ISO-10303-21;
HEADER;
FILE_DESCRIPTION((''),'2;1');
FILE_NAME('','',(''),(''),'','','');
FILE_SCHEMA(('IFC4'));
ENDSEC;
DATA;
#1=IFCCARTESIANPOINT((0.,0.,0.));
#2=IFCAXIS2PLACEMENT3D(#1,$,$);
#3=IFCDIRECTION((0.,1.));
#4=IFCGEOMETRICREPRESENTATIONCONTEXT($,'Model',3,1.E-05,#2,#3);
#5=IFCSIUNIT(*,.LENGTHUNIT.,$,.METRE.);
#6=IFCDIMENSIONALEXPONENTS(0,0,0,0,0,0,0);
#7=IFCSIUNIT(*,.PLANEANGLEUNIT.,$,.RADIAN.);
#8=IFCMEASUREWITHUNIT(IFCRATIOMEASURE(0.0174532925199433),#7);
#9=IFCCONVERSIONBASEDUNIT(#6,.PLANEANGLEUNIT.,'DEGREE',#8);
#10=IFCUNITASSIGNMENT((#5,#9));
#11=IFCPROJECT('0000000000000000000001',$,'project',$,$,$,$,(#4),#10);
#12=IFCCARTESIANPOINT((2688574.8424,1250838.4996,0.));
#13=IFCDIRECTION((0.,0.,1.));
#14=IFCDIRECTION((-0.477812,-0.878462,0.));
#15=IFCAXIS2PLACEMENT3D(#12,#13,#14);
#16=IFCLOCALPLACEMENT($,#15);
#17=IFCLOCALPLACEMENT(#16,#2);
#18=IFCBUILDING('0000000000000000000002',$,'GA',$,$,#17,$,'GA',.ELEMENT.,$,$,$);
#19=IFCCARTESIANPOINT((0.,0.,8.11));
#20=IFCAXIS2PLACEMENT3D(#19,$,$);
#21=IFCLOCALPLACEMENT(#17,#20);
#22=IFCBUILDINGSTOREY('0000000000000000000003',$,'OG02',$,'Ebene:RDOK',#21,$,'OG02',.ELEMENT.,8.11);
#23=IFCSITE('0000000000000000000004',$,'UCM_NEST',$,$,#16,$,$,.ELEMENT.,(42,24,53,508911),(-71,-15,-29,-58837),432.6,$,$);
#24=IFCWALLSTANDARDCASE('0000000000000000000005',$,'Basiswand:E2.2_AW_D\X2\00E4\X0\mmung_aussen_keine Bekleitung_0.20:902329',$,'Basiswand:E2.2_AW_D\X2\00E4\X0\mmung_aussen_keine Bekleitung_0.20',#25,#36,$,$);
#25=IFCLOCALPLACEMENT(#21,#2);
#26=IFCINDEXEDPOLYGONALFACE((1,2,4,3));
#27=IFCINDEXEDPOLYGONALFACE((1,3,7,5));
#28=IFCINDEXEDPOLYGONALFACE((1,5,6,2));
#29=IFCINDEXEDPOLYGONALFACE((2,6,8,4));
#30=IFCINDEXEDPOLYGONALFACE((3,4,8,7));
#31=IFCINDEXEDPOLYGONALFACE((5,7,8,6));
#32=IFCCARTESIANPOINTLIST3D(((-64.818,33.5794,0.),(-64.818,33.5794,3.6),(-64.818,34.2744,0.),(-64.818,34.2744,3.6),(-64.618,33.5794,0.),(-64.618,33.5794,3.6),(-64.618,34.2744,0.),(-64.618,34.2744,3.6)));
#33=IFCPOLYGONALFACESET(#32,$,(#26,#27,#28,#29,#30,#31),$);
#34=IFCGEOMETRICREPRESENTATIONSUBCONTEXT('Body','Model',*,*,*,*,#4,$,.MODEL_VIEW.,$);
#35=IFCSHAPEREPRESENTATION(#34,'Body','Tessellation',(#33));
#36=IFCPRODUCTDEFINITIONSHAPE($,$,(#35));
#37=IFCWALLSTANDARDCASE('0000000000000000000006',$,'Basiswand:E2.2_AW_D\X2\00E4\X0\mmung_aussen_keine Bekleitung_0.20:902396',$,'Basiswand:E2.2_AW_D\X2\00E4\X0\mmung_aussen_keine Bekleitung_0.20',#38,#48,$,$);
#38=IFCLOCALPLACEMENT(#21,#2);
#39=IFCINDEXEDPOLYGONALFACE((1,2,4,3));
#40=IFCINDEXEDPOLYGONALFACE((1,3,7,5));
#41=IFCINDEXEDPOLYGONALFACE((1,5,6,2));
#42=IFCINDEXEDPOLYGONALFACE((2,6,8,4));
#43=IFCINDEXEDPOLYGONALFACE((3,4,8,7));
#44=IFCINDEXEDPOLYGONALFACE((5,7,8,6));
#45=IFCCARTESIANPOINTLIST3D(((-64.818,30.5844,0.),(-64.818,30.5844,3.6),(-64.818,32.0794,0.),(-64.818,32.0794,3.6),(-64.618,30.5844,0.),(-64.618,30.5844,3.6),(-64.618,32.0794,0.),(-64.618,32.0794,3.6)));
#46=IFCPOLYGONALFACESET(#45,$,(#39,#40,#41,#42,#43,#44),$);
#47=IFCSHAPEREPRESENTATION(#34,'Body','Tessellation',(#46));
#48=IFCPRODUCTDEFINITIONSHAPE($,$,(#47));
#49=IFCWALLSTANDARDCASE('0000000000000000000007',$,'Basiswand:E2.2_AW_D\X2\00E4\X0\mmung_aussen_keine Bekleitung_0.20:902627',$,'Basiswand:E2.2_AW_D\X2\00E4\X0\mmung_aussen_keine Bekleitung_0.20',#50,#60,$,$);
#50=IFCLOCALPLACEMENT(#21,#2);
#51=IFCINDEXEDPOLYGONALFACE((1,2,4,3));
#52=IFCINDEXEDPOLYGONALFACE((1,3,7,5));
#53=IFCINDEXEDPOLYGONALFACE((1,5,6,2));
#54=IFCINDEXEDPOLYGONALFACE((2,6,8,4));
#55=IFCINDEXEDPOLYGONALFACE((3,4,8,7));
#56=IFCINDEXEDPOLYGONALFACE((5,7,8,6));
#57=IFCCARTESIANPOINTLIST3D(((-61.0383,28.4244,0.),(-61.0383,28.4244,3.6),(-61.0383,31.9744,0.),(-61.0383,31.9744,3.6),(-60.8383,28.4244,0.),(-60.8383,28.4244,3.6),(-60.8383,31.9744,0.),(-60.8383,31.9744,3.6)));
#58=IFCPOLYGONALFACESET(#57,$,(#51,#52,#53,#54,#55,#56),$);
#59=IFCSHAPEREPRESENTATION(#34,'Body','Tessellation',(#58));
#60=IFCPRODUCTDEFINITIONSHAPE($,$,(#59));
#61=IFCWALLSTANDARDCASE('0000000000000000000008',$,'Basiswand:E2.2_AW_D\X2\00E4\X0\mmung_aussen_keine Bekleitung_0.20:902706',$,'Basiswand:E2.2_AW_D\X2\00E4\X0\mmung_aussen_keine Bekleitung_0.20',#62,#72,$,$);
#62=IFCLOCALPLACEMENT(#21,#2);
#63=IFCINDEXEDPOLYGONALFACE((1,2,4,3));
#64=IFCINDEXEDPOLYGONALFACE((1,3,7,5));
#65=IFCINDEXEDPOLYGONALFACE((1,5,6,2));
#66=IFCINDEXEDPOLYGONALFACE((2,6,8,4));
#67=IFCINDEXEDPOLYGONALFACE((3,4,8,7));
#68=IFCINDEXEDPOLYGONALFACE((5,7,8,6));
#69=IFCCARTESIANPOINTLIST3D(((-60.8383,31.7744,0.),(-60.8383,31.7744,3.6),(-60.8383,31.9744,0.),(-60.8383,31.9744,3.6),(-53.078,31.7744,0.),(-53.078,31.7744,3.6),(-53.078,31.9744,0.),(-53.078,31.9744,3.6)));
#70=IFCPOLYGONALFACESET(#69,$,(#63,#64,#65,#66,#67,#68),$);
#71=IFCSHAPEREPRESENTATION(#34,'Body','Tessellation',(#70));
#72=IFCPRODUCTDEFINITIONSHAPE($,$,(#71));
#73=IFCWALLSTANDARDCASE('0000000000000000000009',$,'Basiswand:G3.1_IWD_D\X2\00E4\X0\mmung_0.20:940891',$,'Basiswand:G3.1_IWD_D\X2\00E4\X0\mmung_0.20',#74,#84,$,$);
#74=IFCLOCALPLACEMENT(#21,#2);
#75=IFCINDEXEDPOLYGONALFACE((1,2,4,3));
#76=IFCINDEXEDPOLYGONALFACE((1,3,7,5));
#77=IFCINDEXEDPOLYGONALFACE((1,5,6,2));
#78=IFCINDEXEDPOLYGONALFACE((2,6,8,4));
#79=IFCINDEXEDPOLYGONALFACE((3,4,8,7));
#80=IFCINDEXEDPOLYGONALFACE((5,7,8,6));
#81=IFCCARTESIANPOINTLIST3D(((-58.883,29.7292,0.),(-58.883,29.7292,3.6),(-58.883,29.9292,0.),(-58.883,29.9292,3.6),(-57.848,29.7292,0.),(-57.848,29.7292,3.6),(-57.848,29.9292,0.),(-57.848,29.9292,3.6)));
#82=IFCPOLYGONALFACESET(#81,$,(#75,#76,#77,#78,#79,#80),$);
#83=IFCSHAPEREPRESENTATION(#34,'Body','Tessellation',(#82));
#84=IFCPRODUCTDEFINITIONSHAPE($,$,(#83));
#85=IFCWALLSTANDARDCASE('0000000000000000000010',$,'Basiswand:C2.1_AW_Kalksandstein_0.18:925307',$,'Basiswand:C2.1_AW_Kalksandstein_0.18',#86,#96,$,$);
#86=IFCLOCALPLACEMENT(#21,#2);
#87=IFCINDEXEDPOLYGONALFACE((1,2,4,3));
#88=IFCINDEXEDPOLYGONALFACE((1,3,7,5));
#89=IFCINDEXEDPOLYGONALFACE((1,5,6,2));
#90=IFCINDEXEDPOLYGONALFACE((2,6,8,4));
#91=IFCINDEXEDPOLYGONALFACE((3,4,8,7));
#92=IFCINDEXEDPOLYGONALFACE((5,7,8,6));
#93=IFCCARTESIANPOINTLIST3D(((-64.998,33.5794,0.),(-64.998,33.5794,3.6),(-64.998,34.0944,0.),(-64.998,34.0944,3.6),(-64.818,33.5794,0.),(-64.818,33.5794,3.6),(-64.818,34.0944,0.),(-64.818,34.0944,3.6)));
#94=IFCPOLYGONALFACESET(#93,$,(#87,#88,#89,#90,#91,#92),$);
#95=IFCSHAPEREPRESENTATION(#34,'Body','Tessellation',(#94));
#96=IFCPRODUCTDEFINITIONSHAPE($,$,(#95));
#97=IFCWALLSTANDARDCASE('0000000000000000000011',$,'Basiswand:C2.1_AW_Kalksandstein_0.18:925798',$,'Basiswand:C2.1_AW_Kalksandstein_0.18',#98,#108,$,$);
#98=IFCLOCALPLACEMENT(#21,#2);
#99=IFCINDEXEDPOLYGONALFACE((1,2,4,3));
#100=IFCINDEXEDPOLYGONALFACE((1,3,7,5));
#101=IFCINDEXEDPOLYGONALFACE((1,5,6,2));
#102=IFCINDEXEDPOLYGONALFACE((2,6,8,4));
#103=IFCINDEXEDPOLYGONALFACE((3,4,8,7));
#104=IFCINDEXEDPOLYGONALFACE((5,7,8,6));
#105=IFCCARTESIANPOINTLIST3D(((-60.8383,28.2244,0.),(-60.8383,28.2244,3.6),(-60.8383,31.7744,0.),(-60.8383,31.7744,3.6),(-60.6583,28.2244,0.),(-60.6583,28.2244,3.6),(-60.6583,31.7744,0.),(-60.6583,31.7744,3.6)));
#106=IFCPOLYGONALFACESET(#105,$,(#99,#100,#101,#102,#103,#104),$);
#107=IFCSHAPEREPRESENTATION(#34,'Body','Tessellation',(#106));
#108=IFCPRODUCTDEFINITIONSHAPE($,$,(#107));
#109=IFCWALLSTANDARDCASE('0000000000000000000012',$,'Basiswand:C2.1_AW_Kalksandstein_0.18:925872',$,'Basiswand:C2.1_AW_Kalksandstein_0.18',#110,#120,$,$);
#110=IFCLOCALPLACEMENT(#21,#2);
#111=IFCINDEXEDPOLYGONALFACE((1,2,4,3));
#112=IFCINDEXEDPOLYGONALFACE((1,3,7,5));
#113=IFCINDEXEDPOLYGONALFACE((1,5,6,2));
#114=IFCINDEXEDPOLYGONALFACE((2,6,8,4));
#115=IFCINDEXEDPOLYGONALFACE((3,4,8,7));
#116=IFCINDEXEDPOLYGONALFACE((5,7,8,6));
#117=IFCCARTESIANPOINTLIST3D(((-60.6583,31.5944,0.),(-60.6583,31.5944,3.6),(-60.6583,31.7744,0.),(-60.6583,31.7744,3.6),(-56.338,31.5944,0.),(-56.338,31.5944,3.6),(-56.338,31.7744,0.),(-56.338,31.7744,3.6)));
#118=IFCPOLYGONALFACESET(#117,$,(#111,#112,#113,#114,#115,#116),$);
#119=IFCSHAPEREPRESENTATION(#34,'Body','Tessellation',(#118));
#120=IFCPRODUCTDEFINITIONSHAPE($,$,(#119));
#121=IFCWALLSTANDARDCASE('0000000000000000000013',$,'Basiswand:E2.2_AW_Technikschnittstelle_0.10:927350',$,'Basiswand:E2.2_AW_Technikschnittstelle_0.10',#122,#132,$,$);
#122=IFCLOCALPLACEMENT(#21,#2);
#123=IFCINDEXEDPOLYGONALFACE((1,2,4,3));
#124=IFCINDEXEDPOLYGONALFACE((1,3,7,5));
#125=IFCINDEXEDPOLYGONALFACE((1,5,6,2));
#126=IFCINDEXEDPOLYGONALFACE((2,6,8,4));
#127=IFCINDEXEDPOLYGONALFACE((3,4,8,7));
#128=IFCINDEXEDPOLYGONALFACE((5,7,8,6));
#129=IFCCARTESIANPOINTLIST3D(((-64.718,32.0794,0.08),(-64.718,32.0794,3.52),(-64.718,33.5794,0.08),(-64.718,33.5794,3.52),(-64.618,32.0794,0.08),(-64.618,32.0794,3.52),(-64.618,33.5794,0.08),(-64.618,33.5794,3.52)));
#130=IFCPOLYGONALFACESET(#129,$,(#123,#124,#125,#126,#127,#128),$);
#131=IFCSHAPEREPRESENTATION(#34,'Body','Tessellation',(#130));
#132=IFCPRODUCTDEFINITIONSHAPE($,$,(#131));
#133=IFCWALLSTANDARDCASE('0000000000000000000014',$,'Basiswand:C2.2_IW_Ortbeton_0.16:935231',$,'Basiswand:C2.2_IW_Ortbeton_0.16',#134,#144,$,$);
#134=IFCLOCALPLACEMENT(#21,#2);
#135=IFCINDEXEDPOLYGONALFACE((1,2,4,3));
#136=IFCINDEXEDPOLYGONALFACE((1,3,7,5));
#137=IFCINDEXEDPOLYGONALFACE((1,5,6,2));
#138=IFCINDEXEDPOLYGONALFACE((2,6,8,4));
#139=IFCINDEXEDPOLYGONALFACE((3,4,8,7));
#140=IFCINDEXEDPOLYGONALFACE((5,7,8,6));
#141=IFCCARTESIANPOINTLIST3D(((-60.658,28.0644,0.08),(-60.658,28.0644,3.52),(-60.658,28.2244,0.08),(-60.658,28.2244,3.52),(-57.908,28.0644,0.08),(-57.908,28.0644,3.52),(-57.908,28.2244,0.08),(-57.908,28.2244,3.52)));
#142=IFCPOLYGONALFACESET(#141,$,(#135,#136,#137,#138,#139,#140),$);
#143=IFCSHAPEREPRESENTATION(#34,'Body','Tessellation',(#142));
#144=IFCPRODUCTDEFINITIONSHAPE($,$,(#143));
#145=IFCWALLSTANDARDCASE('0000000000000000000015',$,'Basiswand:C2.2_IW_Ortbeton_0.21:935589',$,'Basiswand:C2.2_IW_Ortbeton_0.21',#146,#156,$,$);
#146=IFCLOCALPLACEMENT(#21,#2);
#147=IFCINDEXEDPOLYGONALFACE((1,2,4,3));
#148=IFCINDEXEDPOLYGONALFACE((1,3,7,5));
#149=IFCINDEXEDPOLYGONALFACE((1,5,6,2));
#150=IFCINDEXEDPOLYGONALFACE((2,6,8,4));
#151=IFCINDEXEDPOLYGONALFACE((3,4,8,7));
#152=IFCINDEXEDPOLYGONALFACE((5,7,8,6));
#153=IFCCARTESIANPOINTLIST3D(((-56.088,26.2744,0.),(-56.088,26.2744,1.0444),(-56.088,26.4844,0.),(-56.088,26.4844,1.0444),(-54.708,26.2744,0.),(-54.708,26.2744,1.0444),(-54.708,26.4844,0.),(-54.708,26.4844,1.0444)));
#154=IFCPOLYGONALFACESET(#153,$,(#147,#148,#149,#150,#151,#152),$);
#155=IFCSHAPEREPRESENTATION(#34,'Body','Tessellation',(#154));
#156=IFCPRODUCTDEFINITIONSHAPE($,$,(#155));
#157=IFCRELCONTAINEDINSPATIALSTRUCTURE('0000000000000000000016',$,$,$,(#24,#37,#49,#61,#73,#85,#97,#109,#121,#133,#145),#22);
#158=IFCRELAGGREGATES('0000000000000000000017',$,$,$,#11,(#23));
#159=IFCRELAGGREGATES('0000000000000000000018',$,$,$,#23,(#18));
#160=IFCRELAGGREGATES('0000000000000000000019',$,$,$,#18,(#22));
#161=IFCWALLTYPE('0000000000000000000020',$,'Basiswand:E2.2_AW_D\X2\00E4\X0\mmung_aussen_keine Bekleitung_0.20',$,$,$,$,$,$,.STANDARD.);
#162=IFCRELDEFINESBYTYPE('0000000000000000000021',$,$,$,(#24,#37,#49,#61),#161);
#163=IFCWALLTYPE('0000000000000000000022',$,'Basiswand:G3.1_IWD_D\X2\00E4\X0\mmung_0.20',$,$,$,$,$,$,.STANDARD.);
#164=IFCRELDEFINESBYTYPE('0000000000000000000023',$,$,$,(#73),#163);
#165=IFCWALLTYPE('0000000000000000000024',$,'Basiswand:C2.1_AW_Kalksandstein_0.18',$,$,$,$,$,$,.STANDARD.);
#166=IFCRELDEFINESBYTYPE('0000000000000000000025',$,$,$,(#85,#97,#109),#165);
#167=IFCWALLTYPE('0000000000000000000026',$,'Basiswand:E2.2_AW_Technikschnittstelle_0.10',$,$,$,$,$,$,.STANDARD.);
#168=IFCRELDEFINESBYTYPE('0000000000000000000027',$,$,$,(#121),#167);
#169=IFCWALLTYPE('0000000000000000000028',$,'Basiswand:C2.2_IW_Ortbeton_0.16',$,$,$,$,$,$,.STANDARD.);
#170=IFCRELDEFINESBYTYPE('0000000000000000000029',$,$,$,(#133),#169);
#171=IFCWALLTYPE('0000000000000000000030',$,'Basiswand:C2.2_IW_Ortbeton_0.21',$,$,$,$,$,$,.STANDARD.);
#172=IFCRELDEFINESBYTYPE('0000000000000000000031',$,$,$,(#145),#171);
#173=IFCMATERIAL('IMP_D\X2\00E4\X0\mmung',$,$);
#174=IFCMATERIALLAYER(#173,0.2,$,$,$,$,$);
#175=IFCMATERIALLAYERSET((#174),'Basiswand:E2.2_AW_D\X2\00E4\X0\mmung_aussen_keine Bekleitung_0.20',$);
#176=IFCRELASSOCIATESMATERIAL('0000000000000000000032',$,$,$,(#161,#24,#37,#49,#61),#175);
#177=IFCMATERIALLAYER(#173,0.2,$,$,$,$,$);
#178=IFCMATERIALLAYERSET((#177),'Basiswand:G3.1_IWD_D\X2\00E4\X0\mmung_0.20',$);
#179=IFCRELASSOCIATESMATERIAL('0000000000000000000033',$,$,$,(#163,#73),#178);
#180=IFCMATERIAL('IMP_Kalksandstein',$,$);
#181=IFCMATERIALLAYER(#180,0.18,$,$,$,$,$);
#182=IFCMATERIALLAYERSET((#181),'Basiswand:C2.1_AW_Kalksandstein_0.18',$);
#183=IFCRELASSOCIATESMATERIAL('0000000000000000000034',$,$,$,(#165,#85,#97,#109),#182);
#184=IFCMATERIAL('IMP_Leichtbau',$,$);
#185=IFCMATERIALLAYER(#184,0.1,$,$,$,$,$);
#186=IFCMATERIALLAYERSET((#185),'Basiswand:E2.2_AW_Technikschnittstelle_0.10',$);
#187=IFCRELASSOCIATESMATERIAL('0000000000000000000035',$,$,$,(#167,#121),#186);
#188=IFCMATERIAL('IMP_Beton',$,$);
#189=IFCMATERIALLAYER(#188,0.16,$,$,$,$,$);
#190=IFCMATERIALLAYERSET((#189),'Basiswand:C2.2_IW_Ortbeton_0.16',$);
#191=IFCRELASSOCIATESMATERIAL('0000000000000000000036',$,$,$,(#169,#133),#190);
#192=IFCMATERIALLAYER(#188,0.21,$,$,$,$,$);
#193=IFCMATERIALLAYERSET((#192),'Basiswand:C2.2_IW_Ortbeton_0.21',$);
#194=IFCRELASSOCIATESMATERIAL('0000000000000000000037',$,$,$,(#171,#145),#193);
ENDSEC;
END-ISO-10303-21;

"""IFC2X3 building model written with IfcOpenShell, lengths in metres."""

from ifc_helpers import new_model, entity, si_unit, converted_unit, direction, frame, frame_2d, origin, place, context, subcontext, project, spatial, polyline, rectangle, extrude, clip, bounded_halfspace, material, layer, layer_set, layer_usage, type_object, element, save


model = new_model("IFC2X3")

# Units and contexts
model_context = context("Model", 3, precision=1e-05, world=origin(), true_north=direction((0.0, 1.0)))
body_context = subcontext(model_context, "Body", "Model", "MODEL_VIEW")
ifc_project = project(units=[si_unit("LENGTHUNIT", "METRE"), converted_unit("PLANEANGLEUNIT", "DEGREE", entity("IfcRatioMeasure", 0.0174532925199433), si_unit("PLANEANGLEUNIT", "RADIAN"), dimensions=[0, 0, 0, 0, 0, 0, 0])], contexts=[model_context])

# Site, building, storey
site_placement = place(None, frame((2688574.8424, 1250838.4996, 0.0), z_axis=(0.0, 0.0, 1.0), x_axis=(-0.477812, -0.878462, 0.0)))
site = spatial("IfcSite", under=ifc_project, at=site_placement, Name="UCM_NEST", CompositionType="ELEMENT", RefLatitude=(42, 24, 53, 508911), RefLongitude=(-71, -15, -29, -58837), RefElevation=432.6)
building_placement = place(site_placement, origin())
building = spatial("IfcBuilding", under=site, at=building_placement, Name="GA", LongName="GA", CompositionType="ELEMENT")
storey_placement = place(building_placement, frame((0.0, 0.0, 8.11)))
storey = spatial("IfcBuildingStorey", under=building, at=storey_placement, Name="OG02", ObjectType="Ebene:RDOK", LongName="OG02", CompositionType="ELEMENT", Elevation=8.11)

# Walls
ifc_material_1 = material(Name="IMP_Dämmung")
ifc_layer_1 = layer(ifc_material_1, 0.2)
ifc_layer_set_1 = layer_set([ifc_layer_1], Name="Basiswand:E2.2_AW_Dämmung_aussen_keine Bekleitung_0.20")
ifc_layer_usage_1 = layer_usage(ifc_layer_set_1, "AXIS2", "NEGATIVE", 0.1)
wall_type_1 = type_object("IfcWallType", Name="Basiswand:E2.2_AW_Dämmung_aussen_keine Bekleitung_0.20", PredefinedType="STANDARD", material=ifc_layer_set_1)
wall_1_placement = place(storey_placement, frame((-64.718, 34.2744, 0.0), z_axis=(0.0, 0.0, 1.0), x_axis=(0.0, -1.0, 0.0)))
element("IfcWallStandardCase", 1, at=wall_1_placement, inside=storey, type_object=wall_type_1, material=ifc_layer_usage_1, Name="Basiswand:E2.2_AW_Dämmung_aussen_keine Bekleitung_0.20:902329", ObjectType="Basiswand:E2.2_AW_Dämmung_aussen_keine Bekleitung_0.20", context=body_context, shape_type="SweptSolid", body=[
    extrude(rectangle(XDim=0.695, YDim=0.2, at=frame_2d((0.3475, 0.0), x_axis=(-1.0, 0.0))), origin(), (0.0, 0.0, 1.0), 3.6),
])
ifc_layer_usage_2 = layer_usage(ifc_layer_set_1, "AXIS2", "NEGATIVE", 0.1)
wall_2_placement = place(storey_placement, frame((-64.718, 32.0794, 0.0), z_axis=(0.0, 0.0, 1.0), x_axis=(0.0, -1.0, 0.0)))
element("IfcWallStandardCase", 2, at=wall_2_placement, inside=storey, type_object=wall_type_1, material=ifc_layer_usage_2, Name="Basiswand:E2.2_AW_Dämmung_aussen_keine Bekleitung_0.20:902396", ObjectType="Basiswand:E2.2_AW_Dämmung_aussen_keine Bekleitung_0.20", context=body_context, shape_type="SweptSolid", body=[
    extrude(rectangle(XDim=1.495, YDim=0.2, at=frame_2d((0.7475, 0.0), x_axis=(-1.0, 0.0))), origin(), (0.0, 0.0, 1.0), 3.6),
])
ifc_layer_usage_3 = layer_usage(ifc_layer_set_1, "AXIS2", "NEGATIVE", 0.1)
wall_3_placement = place(storey_placement, frame((-60.9383, 28.4244, 0.0), z_axis=(0.0, 0.0, 1.0), x_axis=(0.0, 1.0, 0.0)))
element("IfcWallStandardCase", 3, at=wall_3_placement, inside=storey, type_object=wall_type_1, material=ifc_layer_usage_3, Name="Basiswand:E2.2_AW_Dämmung_aussen_keine Bekleitung_0.20:902627", ObjectType="Basiswand:E2.2_AW_Dämmung_aussen_keine Bekleitung_0.20", context=body_context, shape_type="SweptSolid", body=[
    extrude(rectangle(XDim=3.55, YDim=0.2, at=frame_2d((1.775, 0.0), x_axis=(-1.0, 0.0))), origin(), (0.0, 0.0, 1.0), 3.6),
])
ifc_layer_usage_4 = layer_usage(ifc_layer_set_1, "AXIS2", "NEGATIVE", 0.1)
wall_4_placement = place(storey_placement, frame((-60.8383, 31.8744, 0.0)))
element("IfcWallStandardCase", 4, at=wall_4_placement, inside=storey, type_object=wall_type_1, material=ifc_layer_usage_4, Name="Basiswand:E2.2_AW_Dämmung_aussen_keine Bekleitung_0.20:902706", ObjectType="Basiswand:E2.2_AW_Dämmung_aussen_keine Bekleitung_0.20", context=body_context, shape_type="SweptSolid", body=[
    extrude(rectangle(XDim=7.7603, YDim=0.2, at=frame_2d((3.8801, 0.0), x_axis=(-1.0, 0.0))), origin(), (0.0, 0.0, 1.0), 3.6),
])
ifc_layer_2 = layer(ifc_material_1, 0.2)
ifc_layer_set_2 = layer_set([ifc_layer_2], Name="Basiswand:G3.1_IWD_Dämmung_0.20")
ifc_layer_usage_5 = layer_usage(ifc_layer_set_2, "AXIS2", "NEGATIVE", 0.1)
wall_type_2 = type_object("IfcWallType", Name="Basiswand:G3.1_IWD_Dämmung_0.20", PredefinedType="STANDARD", material=ifc_layer_set_2)
wall_5_placement = place(storey_placement, frame((-57.848, 29.8292, 0.0), z_axis=(0.0, 0.0, 1.0), x_axis=(-1.0, 0.0, 0.0)))
element("IfcWallStandardCase", 5, at=wall_5_placement, inside=storey, type_object=wall_type_2, material=ifc_layer_usage_5, Name="Basiswand:G3.1_IWD_Dämmung_0.20:940891", ObjectType="Basiswand:G3.1_IWD_Dämmung_0.20", context=body_context, shape_type="SweptSolid", body=[
    extrude(rectangle(XDim=1.035, YDim=0.2, at=frame_2d((0.5175, 0.0), x_axis=(-1.0, 0.0))), origin(), (0.0, 0.0, 1.0), 3.6),
])
ifc_material_2 = material(Name="IMP_Kalksandstein")
ifc_layer_3 = layer(ifc_material_2, 0.18)
ifc_layer_set_3 = layer_set([ifc_layer_3], Name="Basiswand:C2.1_AW_Kalksandstein_0.18")
ifc_layer_usage_6 = layer_usage(ifc_layer_set_3, "AXIS2", "NEGATIVE", 0.09)
wall_type_3 = type_object("IfcWallType", Name="Basiswand:C2.1_AW_Kalksandstein_0.18", PredefinedType="STANDARD", material=ifc_layer_set_3)
wall_6_placement = place(storey_placement, frame((-64.908, 34.0944, 0.0), z_axis=(0.0, 0.0, 1.0), x_axis=(0.0, -1.0, 0.0)))
element("IfcWallStandardCase", 6, at=wall_6_placement, inside=storey, type_object=wall_type_3, material=ifc_layer_usage_6, Name="Basiswand:C2.1_AW_Kalksandstein_0.18:925307", ObjectType="Basiswand:C2.1_AW_Kalksandstein_0.18", context=body_context, shape_type="SweptSolid", body=[
    extrude(rectangle(XDim=0.515, YDim=0.18, at=frame_2d((0.2575, 0.0), x_axis=(-1.0, 0.0))), origin(), (0.0, 0.0, 1.0), 3.6),
])
ifc_layer_usage_7 = layer_usage(ifc_layer_set_3, "AXIS2", "NEGATIVE", 0.09)
wall_7_placement = place(storey_placement, frame((-60.7483, 28.2244, 0.0), z_axis=(0.0, 0.0, 1.0), x_axis=(0.0, 1.0, 0.0)))
element("IfcWallStandardCase", 7, at=wall_7_placement, inside=storey, type_object=wall_type_3, material=ifc_layer_usage_7, Name="Basiswand:C2.1_AW_Kalksandstein_0.18:925798", ObjectType="Basiswand:C2.1_AW_Kalksandstein_0.18", context=body_context, shape_type="SweptSolid", body=[
    extrude(rectangle(XDim=3.55, YDim=0.18, at=frame_2d((1.775, 0.0), x_axis=(-1.0, 0.0))), origin(), (0.0, 0.0, 1.0), 3.6),
])
ifc_layer_usage_8 = layer_usage(ifc_layer_set_3, "AXIS2", "NEGATIVE", 0.09)
wall_8_placement = place(storey_placement, frame((-60.6583, 31.6844, 0.0)))
element("IfcWallStandardCase", 8, at=wall_8_placement, inside=storey, type_object=wall_type_3, material=ifc_layer_usage_8, Name="Basiswand:C2.1_AW_Kalksandstein_0.18:925872", ObjectType="Basiswand:C2.1_AW_Kalksandstein_0.18", context=body_context, shape_type="SweptSolid", body=[
    extrude(rectangle(XDim=4.3203, YDim=0.18, at=frame_2d((2.1601, 0.0), x_axis=(-1.0, 0.0))), origin(), (0.0, 0.0, 1.0), 3.6),
])
ifc_material_3 = material(Name="IMP_Leichtbau")
ifc_layer_4 = layer(ifc_material_3, 0.1)
ifc_layer_set_4 = layer_set([ifc_layer_4], Name="Basiswand:E2.2_AW_Technikschnittstelle_0.10")
ifc_layer_usage_9 = layer_usage(ifc_layer_set_4, "AXIS2", "NEGATIVE", 0.05)
wall_type_4 = type_object("IfcWallType", Name="Basiswand:E2.2_AW_Technikschnittstelle_0.10", PredefinedType="STANDARD", material=ifc_layer_set_4)
wall_9_placement = place(storey_placement, frame((-64.668, 33.5794, 0.08), z_axis=(0.0, 0.0, 1.0), x_axis=(0.0, -1.0, 0.0)))
element("IfcWallStandardCase", 9, at=wall_9_placement, inside=storey, type_object=wall_type_4, material=ifc_layer_usage_9, Name="Basiswand:E2.2_AW_Technikschnittstelle_0.10:927350", ObjectType="Basiswand:E2.2_AW_Technikschnittstelle_0.10", context=body_context, shape_type="Clipping", body=[
    clip(clip(extrude(rectangle(XDim=1.5, YDim=0.1, at=frame_2d((0.75, 0.0), x_axis=(-1.0, 0.0))), origin(), (0.0, 0.0, 1.0), 3.44), bounded_halfspace(frame((1.5, -0.05, 0.0), z_axis=(0.0, 0.0, 1.0), x_axis=(0.0, -1.0, 0.0)), True, frame((1.5, -0.05, 0.0), z_axis=(0.0, 0.0, 1.0), x_axis=(0.0, -1.0, 0.0)), polyline([(0.0, 0.0), (-0.1, 0.0), (-0.1, -1.5), (0.0, -1.5), (0.0, 0.0)]))), bounded_halfspace(frame((0.0, -0.05, 3.44), z_axis=(0.0, 0.0, -1.0), x_axis=(0.0, -1.0, 0.0)), True, frame((0.0, -0.05, 3.44), z_axis=(0.0, 0.0, -1.0), x_axis=(0.0, -1.0, 0.0)), polyline([(0.0, 0.0), (-0.1, 0.0), (-0.1, -1.5), (0.0, -1.5), (0.0, 0.0)]))),
])
ifc_material_4 = material(Name="IMP_Beton")
ifc_layer_5 = layer(ifc_material_4, 0.16)
ifc_layer_set_5 = layer_set([ifc_layer_5], Name="Basiswand:C2.2_IW_Ortbeton_0.16")
ifc_layer_usage_10 = layer_usage(ifc_layer_set_5, "AXIS2", "NEGATIVE", 0.08)
wall_type_5 = type_object("IfcWallType", Name="Basiswand:C2.2_IW_Ortbeton_0.16", PredefinedType="STANDARD", material=ifc_layer_set_5)
wall_10_placement = place(storey_placement, frame((-60.658, 28.1444, 0.08)))
element("IfcWallStandardCase", 10, at=wall_10_placement, inside=storey, type_object=wall_type_5, material=ifc_layer_usage_10, Name="Basiswand:C2.2_IW_Ortbeton_0.16:935231", ObjectType="Basiswand:C2.2_IW_Ortbeton_0.16", context=body_context, shape_type="Clipping", body=[
    clip(clip(extrude(rectangle(XDim=2.75, YDim=0.16, at=frame_2d((1.375, 0.0), x_axis=(-1.0, 0.0))), origin(), (0.0, 0.0, 1.0), 3.44), bounded_halfspace(frame((2.75, -0.08, 0.0), z_axis=(0.0, 0.0, 1.0), x_axis=(-1.0, 0.0, 0.0)), True, frame((2.75, -0.08, 0.0), z_axis=(0.0, 0.0, 1.0), x_axis=(-1.0, 0.0, 0.0)), polyline([(0.0, 0.0), (0.0, -0.16), (2.75, -0.16), (2.75, 0.0), (0.0, 0.0)]))), bounded_halfspace(frame((0.0, -0.08, 3.44), z_axis=(0.0, 0.0, -1.0), x_axis=(-1.0, 0.0, 0.0)), True, frame((0.0, -0.08, 3.44), z_axis=(0.0, 0.0, -1.0), x_axis=(-1.0, 0.0, 0.0)), polyline([(0.0, 0.0), (0.0, 0.16), (-2.75, 0.16), (-2.75, 0.0), (0.0, 0.0)]))),
])
ifc_layer_6 = layer(ifc_material_4, 0.21)
ifc_layer_set_6 = layer_set([ifc_layer_6], Name="Basiswand:C2.2_IW_Ortbeton_0.21")
ifc_layer_usage_11 = layer_usage(ifc_layer_set_6, "AXIS2", "NEGATIVE", 0.105)
wall_type_6 = type_object("IfcWallType", Name="Basiswand:C2.2_IW_Ortbeton_0.21", PredefinedType="STANDARD", material=ifc_layer_set_6)
wall_11_placement = place(storey_placement, frame((-56.088, 26.3794, 0.0)))
element("IfcWallStandardCase", 11, at=wall_11_placement, inside=storey, type_object=wall_type_6, material=ifc_layer_usage_11, Name="Basiswand:C2.2_IW_Ortbeton_0.21:935589", ObjectType="Basiswand:C2.2_IW_Ortbeton_0.21", context=body_context, shape_type="SweptSolid", body=[
    extrude(rectangle(XDim=1.38, YDim=0.21, at=frame_2d((0.69, 0.0), x_axis=(-1.0, 0.0))), origin(), (0.0, 0.0, 1.0), 1.0444),
])

save(model, "model.ifc")
